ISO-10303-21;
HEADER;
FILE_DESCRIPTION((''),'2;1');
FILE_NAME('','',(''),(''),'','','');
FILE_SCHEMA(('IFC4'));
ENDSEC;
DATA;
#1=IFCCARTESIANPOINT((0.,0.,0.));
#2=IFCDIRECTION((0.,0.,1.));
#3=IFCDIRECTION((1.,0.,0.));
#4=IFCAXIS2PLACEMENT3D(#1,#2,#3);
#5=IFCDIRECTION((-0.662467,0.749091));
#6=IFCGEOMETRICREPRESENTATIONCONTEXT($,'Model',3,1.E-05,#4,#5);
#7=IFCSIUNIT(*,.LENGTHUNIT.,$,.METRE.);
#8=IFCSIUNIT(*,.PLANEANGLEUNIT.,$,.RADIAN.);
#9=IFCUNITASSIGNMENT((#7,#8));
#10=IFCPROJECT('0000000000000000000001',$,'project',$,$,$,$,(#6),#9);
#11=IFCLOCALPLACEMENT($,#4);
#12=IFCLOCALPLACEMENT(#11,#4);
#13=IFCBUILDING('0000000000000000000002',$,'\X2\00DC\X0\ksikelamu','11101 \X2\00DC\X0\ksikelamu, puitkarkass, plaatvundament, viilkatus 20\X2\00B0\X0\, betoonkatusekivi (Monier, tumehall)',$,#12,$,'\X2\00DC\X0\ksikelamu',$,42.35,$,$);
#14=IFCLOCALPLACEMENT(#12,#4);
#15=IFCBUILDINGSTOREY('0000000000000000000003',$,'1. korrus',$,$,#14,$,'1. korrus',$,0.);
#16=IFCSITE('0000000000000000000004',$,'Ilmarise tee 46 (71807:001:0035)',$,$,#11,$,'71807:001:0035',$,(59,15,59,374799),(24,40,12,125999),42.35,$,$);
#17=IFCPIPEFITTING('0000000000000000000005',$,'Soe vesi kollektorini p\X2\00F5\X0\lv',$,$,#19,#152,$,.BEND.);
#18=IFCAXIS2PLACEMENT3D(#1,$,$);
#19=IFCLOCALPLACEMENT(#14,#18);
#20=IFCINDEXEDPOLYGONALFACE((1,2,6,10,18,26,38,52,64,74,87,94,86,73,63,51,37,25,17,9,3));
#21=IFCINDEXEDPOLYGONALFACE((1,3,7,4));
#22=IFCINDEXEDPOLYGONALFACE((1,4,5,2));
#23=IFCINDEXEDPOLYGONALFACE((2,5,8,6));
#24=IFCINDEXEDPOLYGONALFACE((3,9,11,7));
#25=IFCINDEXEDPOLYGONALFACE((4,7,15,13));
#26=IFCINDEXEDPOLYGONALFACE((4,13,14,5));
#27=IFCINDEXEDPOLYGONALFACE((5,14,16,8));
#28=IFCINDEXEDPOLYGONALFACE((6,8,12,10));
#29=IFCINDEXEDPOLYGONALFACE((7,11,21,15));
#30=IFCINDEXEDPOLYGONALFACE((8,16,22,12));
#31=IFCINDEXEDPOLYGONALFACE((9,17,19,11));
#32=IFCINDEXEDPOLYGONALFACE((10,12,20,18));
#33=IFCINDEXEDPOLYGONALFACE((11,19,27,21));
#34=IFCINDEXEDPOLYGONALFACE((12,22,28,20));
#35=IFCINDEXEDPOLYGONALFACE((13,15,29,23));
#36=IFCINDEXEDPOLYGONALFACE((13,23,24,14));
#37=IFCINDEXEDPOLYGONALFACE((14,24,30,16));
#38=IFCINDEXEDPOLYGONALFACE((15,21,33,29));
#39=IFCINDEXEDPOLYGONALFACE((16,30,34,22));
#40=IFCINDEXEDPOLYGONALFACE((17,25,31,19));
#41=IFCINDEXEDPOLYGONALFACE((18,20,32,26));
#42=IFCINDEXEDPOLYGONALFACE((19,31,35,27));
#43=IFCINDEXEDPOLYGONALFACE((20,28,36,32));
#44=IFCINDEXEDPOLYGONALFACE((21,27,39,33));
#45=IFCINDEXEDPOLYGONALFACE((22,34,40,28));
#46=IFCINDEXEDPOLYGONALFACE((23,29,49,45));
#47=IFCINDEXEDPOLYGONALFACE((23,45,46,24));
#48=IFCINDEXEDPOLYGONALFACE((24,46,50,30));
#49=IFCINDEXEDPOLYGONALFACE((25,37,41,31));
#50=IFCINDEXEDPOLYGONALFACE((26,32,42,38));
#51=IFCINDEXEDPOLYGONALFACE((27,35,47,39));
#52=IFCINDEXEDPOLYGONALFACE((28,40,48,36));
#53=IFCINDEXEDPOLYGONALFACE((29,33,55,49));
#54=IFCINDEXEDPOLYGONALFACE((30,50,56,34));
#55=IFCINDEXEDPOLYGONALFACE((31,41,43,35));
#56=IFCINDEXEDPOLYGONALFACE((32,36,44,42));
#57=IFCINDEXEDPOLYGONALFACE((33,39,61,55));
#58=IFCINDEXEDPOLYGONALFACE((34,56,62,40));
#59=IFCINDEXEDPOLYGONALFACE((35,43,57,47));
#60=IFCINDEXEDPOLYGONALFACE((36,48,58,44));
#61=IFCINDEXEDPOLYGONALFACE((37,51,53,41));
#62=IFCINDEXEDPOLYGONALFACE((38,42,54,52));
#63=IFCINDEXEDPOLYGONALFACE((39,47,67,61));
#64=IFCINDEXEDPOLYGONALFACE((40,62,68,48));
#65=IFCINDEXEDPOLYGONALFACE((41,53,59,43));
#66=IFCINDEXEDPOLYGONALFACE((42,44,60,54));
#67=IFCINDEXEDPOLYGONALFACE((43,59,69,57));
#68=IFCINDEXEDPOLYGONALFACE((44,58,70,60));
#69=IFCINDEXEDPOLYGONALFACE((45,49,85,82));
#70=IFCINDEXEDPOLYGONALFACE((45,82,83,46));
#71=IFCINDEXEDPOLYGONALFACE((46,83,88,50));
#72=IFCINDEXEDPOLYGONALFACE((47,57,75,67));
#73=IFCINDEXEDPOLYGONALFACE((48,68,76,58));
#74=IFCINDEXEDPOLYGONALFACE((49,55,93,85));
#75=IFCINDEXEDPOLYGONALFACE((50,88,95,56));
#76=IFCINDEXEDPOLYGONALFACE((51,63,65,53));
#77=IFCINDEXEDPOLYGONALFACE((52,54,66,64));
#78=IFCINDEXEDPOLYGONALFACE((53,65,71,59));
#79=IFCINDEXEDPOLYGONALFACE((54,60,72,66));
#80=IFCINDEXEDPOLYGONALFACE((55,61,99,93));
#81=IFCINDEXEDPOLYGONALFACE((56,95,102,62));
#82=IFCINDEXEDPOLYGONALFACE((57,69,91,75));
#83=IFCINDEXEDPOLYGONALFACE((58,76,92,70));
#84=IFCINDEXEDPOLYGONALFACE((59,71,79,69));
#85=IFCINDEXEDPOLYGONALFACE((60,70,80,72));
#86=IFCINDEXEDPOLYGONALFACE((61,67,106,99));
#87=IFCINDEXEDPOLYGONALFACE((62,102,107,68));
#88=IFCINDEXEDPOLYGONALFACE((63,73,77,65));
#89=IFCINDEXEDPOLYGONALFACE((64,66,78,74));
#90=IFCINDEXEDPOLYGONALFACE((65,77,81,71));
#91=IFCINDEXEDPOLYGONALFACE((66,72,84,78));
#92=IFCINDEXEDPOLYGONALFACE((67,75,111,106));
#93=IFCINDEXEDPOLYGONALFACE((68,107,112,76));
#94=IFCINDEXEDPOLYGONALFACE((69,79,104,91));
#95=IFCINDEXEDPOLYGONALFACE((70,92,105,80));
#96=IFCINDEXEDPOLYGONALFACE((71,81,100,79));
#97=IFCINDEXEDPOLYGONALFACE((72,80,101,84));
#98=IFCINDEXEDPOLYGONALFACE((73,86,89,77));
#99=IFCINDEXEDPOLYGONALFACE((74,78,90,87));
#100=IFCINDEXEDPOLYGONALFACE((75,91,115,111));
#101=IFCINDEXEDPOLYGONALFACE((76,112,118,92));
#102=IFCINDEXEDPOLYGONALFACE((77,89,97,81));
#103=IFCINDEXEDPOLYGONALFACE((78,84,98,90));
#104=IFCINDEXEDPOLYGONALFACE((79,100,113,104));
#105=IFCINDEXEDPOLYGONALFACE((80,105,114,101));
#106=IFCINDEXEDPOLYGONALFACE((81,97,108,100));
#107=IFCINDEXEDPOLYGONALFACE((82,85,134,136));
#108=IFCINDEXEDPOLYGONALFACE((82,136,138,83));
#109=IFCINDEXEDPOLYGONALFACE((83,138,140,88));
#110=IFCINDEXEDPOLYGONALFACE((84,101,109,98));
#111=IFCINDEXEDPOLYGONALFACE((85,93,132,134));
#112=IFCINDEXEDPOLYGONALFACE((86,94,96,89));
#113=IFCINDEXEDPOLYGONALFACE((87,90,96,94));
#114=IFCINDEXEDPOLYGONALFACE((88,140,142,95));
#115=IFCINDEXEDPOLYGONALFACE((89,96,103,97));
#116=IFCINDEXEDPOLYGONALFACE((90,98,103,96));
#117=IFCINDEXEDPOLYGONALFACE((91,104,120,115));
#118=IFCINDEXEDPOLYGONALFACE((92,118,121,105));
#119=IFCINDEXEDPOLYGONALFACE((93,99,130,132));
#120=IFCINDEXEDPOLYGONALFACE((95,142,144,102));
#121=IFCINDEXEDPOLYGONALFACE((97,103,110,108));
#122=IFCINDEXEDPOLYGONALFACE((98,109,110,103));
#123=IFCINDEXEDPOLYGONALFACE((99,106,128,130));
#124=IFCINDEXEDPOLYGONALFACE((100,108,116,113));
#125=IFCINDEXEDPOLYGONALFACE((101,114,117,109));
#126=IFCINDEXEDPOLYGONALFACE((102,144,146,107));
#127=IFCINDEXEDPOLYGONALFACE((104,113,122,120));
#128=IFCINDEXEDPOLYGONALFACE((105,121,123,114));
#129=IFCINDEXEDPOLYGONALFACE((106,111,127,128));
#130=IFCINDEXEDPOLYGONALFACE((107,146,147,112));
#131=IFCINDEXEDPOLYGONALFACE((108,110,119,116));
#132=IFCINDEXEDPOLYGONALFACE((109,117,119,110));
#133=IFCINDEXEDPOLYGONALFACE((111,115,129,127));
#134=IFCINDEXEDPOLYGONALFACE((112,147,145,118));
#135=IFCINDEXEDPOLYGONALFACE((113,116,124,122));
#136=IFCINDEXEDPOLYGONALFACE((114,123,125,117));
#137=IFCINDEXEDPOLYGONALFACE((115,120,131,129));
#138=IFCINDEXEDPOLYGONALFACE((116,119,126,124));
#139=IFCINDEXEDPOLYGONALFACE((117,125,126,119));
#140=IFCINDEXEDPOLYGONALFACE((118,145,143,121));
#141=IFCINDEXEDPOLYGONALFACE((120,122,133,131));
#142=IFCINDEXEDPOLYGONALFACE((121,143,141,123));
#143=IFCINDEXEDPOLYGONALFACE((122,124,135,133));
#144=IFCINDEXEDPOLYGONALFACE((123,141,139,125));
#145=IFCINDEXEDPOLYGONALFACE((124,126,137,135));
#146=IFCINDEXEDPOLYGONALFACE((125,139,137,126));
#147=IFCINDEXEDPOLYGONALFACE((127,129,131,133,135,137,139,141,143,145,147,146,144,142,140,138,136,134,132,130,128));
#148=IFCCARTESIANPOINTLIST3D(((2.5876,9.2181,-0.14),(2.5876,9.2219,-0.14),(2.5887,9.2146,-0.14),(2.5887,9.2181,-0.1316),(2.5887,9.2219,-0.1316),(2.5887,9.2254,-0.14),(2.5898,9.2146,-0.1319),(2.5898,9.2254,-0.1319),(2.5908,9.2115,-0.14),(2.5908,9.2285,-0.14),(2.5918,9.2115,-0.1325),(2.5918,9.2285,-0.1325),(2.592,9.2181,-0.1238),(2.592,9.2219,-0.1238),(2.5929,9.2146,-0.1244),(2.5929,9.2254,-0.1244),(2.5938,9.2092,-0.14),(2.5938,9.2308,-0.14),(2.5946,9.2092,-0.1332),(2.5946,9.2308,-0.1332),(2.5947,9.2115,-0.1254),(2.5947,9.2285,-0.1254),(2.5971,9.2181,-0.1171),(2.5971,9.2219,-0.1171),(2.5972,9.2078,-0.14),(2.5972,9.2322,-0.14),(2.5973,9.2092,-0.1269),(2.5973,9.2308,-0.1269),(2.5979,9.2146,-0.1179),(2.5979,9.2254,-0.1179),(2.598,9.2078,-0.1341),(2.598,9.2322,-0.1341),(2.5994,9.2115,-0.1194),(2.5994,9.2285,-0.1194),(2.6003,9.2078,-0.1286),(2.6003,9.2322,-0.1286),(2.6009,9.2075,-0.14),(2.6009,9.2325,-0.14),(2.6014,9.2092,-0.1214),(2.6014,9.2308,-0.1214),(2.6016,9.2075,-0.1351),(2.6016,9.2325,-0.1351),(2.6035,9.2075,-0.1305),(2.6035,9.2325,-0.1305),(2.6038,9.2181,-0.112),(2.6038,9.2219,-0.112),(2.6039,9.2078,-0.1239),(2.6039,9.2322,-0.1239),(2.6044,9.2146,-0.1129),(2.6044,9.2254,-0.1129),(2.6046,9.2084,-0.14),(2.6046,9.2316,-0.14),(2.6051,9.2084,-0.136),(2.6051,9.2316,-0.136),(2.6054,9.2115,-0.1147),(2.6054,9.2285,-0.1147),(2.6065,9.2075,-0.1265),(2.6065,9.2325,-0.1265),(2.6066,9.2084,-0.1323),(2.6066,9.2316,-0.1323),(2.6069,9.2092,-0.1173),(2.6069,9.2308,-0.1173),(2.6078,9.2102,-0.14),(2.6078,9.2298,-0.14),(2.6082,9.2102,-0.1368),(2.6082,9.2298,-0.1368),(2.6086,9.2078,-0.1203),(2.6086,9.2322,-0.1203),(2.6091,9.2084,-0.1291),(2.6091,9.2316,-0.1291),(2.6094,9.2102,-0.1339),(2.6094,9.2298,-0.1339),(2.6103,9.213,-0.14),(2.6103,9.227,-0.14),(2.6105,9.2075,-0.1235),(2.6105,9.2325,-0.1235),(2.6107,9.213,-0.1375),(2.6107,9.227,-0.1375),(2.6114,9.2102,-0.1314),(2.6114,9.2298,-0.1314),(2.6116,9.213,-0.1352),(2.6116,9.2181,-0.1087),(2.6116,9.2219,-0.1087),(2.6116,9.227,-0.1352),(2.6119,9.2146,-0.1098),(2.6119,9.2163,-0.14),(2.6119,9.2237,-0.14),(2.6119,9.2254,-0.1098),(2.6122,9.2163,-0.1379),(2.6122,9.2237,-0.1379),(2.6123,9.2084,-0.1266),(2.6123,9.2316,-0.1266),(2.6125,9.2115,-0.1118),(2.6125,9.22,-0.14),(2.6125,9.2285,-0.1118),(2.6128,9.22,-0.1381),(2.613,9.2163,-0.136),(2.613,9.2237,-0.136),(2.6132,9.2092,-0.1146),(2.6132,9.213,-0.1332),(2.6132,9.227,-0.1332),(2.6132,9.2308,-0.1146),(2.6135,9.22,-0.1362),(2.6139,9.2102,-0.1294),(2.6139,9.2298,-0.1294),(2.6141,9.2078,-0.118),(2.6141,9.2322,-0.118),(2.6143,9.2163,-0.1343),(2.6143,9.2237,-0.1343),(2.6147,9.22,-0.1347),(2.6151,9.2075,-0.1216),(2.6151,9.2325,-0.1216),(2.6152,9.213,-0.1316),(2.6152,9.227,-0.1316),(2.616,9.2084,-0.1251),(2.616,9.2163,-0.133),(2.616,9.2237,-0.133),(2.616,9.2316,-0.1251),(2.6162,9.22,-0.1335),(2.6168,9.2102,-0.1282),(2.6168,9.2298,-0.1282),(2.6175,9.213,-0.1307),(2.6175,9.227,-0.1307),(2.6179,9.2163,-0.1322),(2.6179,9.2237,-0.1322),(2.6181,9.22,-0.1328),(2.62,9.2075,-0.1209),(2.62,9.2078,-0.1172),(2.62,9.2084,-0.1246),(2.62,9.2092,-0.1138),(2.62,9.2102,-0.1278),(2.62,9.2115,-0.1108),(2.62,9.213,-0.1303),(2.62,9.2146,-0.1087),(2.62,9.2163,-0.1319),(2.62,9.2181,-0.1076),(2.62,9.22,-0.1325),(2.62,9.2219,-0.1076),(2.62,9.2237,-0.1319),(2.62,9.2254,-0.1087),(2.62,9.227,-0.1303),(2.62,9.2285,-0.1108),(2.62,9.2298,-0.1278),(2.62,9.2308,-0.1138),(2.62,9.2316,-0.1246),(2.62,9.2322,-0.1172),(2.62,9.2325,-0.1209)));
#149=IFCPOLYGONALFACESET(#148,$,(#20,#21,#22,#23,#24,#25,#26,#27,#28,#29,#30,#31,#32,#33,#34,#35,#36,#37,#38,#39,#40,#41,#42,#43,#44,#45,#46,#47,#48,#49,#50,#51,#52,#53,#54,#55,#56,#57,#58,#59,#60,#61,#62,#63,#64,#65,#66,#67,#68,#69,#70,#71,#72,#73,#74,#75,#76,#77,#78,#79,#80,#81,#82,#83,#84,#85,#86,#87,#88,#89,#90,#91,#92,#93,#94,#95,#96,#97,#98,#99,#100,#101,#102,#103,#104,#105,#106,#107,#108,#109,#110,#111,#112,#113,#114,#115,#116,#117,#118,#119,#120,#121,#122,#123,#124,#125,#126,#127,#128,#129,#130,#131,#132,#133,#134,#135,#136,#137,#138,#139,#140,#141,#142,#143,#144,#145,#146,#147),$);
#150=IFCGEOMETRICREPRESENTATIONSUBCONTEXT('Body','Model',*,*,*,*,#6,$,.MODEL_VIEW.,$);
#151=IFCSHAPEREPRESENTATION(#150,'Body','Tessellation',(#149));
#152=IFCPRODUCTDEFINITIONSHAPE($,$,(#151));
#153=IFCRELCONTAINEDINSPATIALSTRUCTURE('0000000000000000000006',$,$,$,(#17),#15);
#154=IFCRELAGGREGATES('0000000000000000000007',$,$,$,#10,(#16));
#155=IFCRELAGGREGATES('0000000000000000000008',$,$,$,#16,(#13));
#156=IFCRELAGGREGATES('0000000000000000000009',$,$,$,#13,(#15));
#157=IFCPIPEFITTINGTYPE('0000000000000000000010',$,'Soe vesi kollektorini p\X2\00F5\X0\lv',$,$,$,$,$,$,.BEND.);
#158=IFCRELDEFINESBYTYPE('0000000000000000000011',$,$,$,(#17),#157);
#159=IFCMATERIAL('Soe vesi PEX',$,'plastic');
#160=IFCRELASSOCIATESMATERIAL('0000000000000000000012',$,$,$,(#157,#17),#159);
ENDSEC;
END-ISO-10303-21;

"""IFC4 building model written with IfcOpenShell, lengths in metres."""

from ifc_helpers import new_model, entity, si_unit, direction, frame, origin_with_axes, place, context, subcontext, project, spatial, material, type_object, element, save


model = new_model("IFC4")

# Units and contexts
model_context = context("Model", 3, precision=1e-05, world=origin_with_axes(), true_north=direction((-0.662467, 0.749091)))
body_context = subcontext(model_context, "Body", "Model", "MODEL_VIEW")
ifc_project = project(units=[si_unit("LENGTHUNIT", "METRE"), si_unit("PLANEANGLEUNIT", "RADIAN")], contexts=[model_context])

# Site, building, storey
site_placement = place(None, origin_with_axes())
site = spatial("IfcSite", under=ifc_project, at=site_placement, Name="Ilmarise tee 46 (71807:001:0035)", LongName="71807:001:0035", RefLatitude=(59, 15, 59, 374799), RefLongitude=(24, 40, 12, 125999), RefElevation=42.35)
building_placement = place(site_placement, origin_with_axes())
building = spatial("IfcBuilding", under=site, at=building_placement, Name="Üksikelamu", Description="11101 Üksikelamu, puitkarkass, plaatvundament, viilkatus 20°, betoonkatusekivi (Monier, tumehall)", LongName="Üksikelamu", ElevationOfRefHeight=42.35)
storey_placement = place(building_placement, origin_with_axes())
storey = spatial("IfcBuildingStorey", under=building, at=storey_placement, Name="1. korrus", LongName="1. korrus", Elevation=0.0)

# Pipe fitting
ifc_material_1 = material(Name="Soe vesi PEX", Category="plastic")
pipe_fitting_type_1 = type_object("IfcPipeFittingType", Name="Soe vesi kollektorini põlv", PredefinedType="BEND", material=ifc_material_1)
pipe_fitting_1_placement = place(storey_placement, frame((2.6, 9.22, -0.12), z_axis=(0.0, 0.0, 1.0), x_axis=(1.0, 0.0, 0.0)))
element("IfcPipeFitting", 1, at=pipe_fitting_1_placement, inside=storey, type_object=pipe_fitting_type_1, material=ifc_material_1, Name="Soe vesi kollektorini põlv", PredefinedType="BEND", context=body_context, shape_type="SweptSolid", body=[
    entity("IfcRevolvedAreaSolid", entity("IfcCircleProfileDef", "AREA", None, None, 0.0125), entity("IfcAxis2Placement3D", entity("IfcCartesianPoint", [0.02, 0.0, 0.0]), entity("IfcDirection", [-1.0, 0.0, 0.0]), entity("IfcDirection", [0.0, 0.0, -1.0])), entity("IfcAxis1Placement", entity("IfcCartesianPoint", [0.02, 0.0, 0.0]), entity("IfcDirection", [0.0, 1.0, 0.0])), 1.570796),
])

save(model, "model.ifc")
